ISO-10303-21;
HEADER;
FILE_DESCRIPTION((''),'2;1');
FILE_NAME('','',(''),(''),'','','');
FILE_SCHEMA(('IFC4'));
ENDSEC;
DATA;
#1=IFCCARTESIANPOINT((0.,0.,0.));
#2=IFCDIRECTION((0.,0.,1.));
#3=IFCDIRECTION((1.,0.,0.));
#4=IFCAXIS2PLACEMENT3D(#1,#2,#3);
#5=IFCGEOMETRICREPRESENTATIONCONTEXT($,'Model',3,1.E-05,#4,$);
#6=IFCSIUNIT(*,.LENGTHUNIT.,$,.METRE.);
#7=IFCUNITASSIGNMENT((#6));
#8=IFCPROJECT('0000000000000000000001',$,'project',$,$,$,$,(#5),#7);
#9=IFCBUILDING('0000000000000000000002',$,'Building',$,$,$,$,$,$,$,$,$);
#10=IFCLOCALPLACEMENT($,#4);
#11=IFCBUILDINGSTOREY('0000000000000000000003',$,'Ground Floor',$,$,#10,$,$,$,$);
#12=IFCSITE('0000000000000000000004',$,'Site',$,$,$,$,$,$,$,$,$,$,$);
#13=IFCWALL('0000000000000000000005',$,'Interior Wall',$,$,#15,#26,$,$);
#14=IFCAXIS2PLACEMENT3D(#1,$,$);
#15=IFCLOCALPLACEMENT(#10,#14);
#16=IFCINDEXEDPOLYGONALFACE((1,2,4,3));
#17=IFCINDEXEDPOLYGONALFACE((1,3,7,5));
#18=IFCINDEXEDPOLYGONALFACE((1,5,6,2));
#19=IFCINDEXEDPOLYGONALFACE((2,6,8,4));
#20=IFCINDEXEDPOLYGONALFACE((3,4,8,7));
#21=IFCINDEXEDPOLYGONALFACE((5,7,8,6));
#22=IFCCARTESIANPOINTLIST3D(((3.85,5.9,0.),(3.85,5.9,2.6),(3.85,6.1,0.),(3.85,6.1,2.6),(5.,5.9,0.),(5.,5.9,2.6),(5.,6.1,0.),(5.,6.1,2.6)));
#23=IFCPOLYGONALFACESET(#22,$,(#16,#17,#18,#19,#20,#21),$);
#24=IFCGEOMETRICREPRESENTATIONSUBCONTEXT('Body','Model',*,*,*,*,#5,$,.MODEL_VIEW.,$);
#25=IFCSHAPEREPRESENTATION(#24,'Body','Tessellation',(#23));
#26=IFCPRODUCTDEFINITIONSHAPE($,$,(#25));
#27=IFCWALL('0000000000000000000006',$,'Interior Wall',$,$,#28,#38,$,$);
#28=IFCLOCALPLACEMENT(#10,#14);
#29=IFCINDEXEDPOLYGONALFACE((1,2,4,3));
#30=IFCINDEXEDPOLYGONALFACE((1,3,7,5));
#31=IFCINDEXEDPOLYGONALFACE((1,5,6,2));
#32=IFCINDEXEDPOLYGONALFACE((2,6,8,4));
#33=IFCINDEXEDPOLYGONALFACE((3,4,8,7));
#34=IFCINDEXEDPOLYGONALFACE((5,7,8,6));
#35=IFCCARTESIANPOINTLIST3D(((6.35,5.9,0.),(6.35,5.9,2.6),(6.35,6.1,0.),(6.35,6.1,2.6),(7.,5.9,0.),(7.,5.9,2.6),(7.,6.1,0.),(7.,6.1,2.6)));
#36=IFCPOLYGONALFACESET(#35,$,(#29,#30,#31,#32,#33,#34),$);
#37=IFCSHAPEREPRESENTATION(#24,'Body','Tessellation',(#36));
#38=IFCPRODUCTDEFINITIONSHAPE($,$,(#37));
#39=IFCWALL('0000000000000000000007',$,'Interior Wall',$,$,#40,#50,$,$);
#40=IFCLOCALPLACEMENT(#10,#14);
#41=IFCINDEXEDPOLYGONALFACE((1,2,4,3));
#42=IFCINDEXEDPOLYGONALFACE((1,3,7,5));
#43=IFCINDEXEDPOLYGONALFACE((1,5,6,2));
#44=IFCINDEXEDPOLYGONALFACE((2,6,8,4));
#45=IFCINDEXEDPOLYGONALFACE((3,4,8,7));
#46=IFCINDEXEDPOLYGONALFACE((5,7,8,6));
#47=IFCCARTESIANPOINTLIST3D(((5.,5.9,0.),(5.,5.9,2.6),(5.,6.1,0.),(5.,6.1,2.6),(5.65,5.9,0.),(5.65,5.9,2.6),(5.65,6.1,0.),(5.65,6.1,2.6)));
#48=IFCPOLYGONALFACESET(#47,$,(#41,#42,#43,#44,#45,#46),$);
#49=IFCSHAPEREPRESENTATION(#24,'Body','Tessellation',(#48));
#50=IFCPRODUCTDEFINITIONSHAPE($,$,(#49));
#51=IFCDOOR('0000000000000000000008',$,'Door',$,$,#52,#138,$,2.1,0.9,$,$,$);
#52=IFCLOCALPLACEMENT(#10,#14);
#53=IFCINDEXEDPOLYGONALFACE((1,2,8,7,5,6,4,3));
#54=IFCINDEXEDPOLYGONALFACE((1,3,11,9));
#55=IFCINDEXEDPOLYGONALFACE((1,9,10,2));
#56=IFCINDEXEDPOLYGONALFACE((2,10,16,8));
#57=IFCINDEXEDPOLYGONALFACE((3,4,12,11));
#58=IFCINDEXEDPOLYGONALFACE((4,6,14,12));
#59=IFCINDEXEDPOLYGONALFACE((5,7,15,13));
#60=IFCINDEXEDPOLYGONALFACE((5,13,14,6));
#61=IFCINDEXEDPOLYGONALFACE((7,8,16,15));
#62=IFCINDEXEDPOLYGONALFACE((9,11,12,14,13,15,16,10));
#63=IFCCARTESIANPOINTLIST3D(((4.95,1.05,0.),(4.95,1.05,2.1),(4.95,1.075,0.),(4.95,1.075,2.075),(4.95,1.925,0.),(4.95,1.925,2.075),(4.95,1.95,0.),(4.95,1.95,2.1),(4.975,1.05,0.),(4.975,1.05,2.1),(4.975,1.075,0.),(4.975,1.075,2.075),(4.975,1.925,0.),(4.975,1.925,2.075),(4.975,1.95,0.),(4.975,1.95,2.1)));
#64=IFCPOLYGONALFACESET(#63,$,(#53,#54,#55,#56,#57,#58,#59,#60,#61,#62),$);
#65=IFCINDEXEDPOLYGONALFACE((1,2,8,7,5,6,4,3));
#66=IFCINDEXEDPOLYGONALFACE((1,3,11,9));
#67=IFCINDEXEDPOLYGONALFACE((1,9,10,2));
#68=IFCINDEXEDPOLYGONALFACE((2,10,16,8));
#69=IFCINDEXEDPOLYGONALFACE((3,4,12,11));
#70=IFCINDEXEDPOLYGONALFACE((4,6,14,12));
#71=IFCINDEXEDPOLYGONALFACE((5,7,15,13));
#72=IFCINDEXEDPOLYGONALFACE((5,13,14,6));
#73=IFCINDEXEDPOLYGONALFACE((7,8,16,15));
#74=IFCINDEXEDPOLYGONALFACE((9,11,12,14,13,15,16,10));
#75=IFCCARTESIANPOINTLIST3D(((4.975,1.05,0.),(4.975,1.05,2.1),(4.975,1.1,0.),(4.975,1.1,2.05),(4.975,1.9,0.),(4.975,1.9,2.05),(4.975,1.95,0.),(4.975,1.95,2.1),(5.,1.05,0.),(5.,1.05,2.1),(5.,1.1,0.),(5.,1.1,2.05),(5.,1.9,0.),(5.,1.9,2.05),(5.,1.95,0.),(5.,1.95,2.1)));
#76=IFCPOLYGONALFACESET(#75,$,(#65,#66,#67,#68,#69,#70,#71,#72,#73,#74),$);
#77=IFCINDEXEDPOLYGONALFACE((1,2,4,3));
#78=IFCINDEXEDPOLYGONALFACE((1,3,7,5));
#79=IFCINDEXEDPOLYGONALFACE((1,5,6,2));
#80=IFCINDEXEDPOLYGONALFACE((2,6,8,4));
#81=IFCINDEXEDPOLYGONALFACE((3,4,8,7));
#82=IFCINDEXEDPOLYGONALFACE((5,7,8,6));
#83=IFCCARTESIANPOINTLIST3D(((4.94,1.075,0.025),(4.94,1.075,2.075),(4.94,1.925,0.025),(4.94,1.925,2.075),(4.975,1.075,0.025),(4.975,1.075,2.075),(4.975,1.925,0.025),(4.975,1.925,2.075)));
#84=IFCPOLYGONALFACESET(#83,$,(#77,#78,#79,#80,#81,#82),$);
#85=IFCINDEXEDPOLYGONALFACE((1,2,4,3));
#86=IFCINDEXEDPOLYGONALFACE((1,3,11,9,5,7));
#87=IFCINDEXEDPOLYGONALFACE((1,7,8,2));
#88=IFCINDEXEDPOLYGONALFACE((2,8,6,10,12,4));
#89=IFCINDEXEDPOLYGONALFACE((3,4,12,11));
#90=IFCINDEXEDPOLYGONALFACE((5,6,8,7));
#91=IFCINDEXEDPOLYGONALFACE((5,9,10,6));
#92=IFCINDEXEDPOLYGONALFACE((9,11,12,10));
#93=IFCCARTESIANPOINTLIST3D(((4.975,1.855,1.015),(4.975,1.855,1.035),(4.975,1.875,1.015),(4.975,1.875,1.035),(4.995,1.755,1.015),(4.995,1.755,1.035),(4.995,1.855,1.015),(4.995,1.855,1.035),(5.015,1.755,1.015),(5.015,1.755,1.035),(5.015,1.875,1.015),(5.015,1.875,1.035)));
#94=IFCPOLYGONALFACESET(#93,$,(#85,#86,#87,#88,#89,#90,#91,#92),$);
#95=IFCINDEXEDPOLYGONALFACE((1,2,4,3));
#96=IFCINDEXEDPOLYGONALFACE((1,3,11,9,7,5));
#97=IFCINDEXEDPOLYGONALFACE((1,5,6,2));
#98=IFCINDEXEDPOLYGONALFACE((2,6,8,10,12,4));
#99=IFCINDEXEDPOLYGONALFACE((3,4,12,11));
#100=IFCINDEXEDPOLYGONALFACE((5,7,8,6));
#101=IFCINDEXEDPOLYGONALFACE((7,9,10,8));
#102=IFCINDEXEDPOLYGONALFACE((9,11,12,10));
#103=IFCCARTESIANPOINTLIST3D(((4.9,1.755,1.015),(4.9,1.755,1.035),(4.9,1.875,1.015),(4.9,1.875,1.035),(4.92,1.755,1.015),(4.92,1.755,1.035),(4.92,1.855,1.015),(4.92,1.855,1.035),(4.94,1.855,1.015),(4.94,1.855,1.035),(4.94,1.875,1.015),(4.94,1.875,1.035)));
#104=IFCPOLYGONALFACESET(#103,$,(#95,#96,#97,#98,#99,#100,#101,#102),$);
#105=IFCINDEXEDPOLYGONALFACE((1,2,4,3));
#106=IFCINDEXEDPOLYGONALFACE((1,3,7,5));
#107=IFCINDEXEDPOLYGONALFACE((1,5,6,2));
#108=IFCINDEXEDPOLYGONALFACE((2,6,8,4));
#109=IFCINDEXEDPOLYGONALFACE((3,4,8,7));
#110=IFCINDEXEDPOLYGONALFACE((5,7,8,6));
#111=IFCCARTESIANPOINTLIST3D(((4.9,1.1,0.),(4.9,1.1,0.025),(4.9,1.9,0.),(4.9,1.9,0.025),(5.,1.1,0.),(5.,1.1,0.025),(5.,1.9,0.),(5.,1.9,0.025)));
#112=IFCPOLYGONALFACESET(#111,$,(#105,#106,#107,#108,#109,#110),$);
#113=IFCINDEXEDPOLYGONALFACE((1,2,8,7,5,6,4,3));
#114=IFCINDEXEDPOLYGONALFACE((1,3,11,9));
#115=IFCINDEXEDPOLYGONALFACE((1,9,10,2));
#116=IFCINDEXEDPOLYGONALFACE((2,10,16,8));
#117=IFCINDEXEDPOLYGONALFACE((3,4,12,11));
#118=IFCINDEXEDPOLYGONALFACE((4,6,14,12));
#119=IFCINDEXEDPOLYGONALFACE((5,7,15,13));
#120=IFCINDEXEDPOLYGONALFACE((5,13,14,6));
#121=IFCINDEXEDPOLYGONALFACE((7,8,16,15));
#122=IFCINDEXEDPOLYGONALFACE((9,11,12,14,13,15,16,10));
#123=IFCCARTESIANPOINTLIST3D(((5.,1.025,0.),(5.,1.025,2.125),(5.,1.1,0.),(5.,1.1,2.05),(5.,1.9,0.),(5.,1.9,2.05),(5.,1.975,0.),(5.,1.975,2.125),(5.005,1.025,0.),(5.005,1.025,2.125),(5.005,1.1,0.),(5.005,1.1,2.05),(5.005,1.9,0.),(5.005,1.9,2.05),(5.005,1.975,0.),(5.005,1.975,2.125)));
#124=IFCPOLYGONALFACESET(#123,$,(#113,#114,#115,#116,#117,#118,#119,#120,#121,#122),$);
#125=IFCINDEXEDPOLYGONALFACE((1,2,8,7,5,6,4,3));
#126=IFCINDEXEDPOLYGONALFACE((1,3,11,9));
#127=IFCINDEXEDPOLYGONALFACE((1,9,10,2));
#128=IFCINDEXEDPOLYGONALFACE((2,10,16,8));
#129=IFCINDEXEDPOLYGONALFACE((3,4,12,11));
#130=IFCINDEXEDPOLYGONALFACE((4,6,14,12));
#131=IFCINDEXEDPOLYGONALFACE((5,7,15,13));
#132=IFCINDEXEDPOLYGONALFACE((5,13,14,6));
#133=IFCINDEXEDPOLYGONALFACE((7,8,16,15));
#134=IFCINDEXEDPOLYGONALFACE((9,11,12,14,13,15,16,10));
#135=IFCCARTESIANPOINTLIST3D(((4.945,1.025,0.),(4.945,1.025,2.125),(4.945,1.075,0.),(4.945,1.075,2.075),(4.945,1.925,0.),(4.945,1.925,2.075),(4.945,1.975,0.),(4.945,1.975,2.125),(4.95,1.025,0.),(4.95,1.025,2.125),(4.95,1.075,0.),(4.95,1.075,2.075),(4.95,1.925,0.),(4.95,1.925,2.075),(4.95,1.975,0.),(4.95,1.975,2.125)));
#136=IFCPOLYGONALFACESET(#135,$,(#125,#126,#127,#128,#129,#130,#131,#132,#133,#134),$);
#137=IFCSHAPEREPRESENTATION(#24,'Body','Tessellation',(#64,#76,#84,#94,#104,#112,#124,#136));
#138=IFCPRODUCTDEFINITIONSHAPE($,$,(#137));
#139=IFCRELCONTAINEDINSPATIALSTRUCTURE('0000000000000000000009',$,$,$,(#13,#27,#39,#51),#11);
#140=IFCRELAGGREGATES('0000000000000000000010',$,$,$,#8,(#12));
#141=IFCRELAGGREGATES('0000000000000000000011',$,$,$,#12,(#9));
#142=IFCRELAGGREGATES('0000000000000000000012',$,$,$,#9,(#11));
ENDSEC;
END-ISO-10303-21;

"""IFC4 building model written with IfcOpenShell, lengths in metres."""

from ifc_helpers import new_model, si_unit, frame, origin_with_axes, place, context, subcontext, project, spatial, line, indexed_curve, outline, extrude, element, save


model = new_model("IFC4")

# Units and contexts
model_context = context("Model", 3, precision=1e-05, world=origin_with_axes())
body_context = subcontext(model_context, "Body", "Model", "MODEL_VIEW")
ifc_project = project(units=[si_unit("LENGTHUNIT", "METRE")], contexts=[model_context])

# Site, building, storey
site = spatial("IfcSite", under=ifc_project, Name="Site")
building = spatial("IfcBuilding", under=site, Name="Building")
storey_placement = place(None, origin_with_axes())
storey = spatial("IfcBuildingStorey", under=building, at=storey_placement, Name="Ground Floor")

# Walls
wall_1_placement = place(storey_placement, frame((5.0, 6.0, 0.0), z_axis=(0.0, 0.0, 1.0), x_axis=(-1.0, 0.0, 0.0)))
element("IfcWall", 1, at=wall_1_placement, inside=storey, Name="Interior Wall", context=body_context, shape_type="SweptSolid", body=[
    extrude(outline(indexed_curve([(0.0, 0.0), (0.0, 0.2), (1.15, 0.2), (1.15, 0.0), (0.0, 0.0)], self_intersect=False)), frame((0.0, -0.1, 0.0), z_axis=(0.0, 0.0, 1.0), x_axis=(1.0, 0.0, 0.0)), (0.0, 0.0, 1.0), 2.6),
])
for number, where, z_axis, x_axis, name in (
    (2, (7.0, 6.0, 0.0), (0.0, 0.0, 1.0), (-1.0, 0.0, 0.0), "Interior Wall"),
    (3, (5.65, 6.0, 0.0), (0.0, 0.0, 1.0), (-1.0, 0.0, 0.0), "Interior Wall"),
):
    element("IfcWall", number, at=place(storey_placement, frame(where, z_axis=z_axis, x_axis=x_axis)), inside=storey, Name=name, context=body_context, shape_type="SweptSolid", body=[
        extrude(outline(indexed_curve([(0.0, 0.0), (0.0, 0.2), (0.65, 0.2), (0.65, 0.0), (0.0, 0.0)], self_intersect=False)), frame((0.0, -0.1, 0.0), z_axis=(0.0, 0.0, 1.0), x_axis=(1.0, 0.0, 0.0)), (0.0, 0.0, 1.0), 2.6),
    ])

# Door
door_1_placement = place(storey_placement, frame((5.0, 1.05, 0.0), z_axis=(0.0, 0.0, 1.0), x_axis=(0.0, 1.0, 0.0)))
element("IfcDoor", 4, at=door_1_placement, inside=storey, Name="Door", OverallHeight=2.1, OverallWidth=0.9, context=body_context, shape_type="SweptSolid", body=[
    extrude(outline(indexed_curve([(0.0, 0.0), (0.0, 2.1), (0.9, 2.1), (0.9, 0.0), (0.875, 0.0), (0.875, 2.075), (0.025, 2.075), (0.025, 0.0)], segments=[line(1, 2, 3, 4, 5, 6, 7, 8, 1)])), frame((0.0, 0.025, 0.0), z_axis=(0.0, -1.0, 0.0), x_axis=(1.0, 0.0, 0.0)), (0.0, 0.0, -1.0), 0.025),
    extrude(outline(indexed_curve([(0.0, 0.0), (0.0, 2.1), (0.9, 2.1), (0.9, 0.0), (0.85, 0.0), (0.85, 2.05), (0.05, 2.05), (0.05, 0.0)], segments=[line(1, 2, 3, 4, 5, 6, 7, 8, 1)])), frame((0.0, 0.0, 0.0), z_axis=(0.0, -1.0, 0.0), x_axis=(1.0, 0.0, 0.0)), (0.0, 0.0, -1.0), 0.025),
    extrude(outline(indexed_curve([(0.0, 0.0), (0.85, 0.0), (0.85, 0.035), (0.0, 0.035)], segments=[line(1, 2, 3, 4, 1)])), frame((0.025, 0.025, 0.025), z_axis=(0.0, 0.0, 1.0), x_axis=(1.0, 0.0, 0.0)), (0.0, 0.0, 1.0), 2.05),
    extrude(outline(indexed_curve([(0.0, 0.0), (0.0, -0.04), (-0.12, -0.04), (-0.12, -0.02), (-0.02, -0.02), (-0.02, 0.0)], segments=[line(1, 2, 3, 4, 5, 6, 1)])), frame((0.825, 0.025, 1.015), z_axis=(0.0, 0.0, 1.0), x_axis=(1.0, 0.0, 0.0)), (0.0, 0.0, 1.0), 0.02),
    extrude(outline(indexed_curve([(0.0, 0.0), (0.0, 0.04), (-0.12, 0.04), (-0.12, 0.02), (-0.02, 0.02), (-0.02, 0.0)], segments=[line(1, 2, 3, 4, 5, 6, 1)])), frame((0.825, 0.06, 1.015), z_axis=(0.0, 0.0, 1.0), x_axis=(1.0, 0.0, 0.0)), (0.0, 0.0, 1.0), 0.02),
    extrude(outline(indexed_curve([(0.0, 0.0), (0.8, 0.0), (0.8, 0.1), (0.0, 0.1)], segments=[line(1, 2, 3, 4, 1)])), frame((0.05, 0.0, 0.0), z_axis=(0.0, 0.0, 1.0), x_axis=(1.0, 0.0, 0.0)), (0.0, 0.0, 1.0), 0.025),
    extrude(outline(indexed_curve([(0.0, 0.0), (0.0, 2.125), (0.95, 2.125), (0.95, 0.0), (0.875, 0.0), (0.875, 2.05), (0.075, 2.05), (0.075, 0.0)], segments=[line(1, 2, 3, 4, 5, 6, 7, 8, 1)])), frame((-0.025, -0.005, 0.0), z_axis=(0.0, -1.0, 0.0), x_axis=(1.0, 0.0, 0.0)), (0.0, 0.0, -1.0), 0.005),
    extrude(outline(indexed_curve([(0.0, 0.0), (0.0, 2.125), (0.95, 2.125), (0.95, 0.0), (0.9, 0.0), (0.9, 2.075), (0.05, 2.075), (0.05, 0.0)], segments=[line(1, 2, 3, 4, 5, 6, 7, 8, 1)])), frame((-0.025, 0.05, 0.0), z_axis=(0.0, -1.0, 0.0), x_axis=(1.0, 0.0, 0.0)), (0.0, 0.0, -1.0), 0.005),
])

save(model, "model.ifc")
